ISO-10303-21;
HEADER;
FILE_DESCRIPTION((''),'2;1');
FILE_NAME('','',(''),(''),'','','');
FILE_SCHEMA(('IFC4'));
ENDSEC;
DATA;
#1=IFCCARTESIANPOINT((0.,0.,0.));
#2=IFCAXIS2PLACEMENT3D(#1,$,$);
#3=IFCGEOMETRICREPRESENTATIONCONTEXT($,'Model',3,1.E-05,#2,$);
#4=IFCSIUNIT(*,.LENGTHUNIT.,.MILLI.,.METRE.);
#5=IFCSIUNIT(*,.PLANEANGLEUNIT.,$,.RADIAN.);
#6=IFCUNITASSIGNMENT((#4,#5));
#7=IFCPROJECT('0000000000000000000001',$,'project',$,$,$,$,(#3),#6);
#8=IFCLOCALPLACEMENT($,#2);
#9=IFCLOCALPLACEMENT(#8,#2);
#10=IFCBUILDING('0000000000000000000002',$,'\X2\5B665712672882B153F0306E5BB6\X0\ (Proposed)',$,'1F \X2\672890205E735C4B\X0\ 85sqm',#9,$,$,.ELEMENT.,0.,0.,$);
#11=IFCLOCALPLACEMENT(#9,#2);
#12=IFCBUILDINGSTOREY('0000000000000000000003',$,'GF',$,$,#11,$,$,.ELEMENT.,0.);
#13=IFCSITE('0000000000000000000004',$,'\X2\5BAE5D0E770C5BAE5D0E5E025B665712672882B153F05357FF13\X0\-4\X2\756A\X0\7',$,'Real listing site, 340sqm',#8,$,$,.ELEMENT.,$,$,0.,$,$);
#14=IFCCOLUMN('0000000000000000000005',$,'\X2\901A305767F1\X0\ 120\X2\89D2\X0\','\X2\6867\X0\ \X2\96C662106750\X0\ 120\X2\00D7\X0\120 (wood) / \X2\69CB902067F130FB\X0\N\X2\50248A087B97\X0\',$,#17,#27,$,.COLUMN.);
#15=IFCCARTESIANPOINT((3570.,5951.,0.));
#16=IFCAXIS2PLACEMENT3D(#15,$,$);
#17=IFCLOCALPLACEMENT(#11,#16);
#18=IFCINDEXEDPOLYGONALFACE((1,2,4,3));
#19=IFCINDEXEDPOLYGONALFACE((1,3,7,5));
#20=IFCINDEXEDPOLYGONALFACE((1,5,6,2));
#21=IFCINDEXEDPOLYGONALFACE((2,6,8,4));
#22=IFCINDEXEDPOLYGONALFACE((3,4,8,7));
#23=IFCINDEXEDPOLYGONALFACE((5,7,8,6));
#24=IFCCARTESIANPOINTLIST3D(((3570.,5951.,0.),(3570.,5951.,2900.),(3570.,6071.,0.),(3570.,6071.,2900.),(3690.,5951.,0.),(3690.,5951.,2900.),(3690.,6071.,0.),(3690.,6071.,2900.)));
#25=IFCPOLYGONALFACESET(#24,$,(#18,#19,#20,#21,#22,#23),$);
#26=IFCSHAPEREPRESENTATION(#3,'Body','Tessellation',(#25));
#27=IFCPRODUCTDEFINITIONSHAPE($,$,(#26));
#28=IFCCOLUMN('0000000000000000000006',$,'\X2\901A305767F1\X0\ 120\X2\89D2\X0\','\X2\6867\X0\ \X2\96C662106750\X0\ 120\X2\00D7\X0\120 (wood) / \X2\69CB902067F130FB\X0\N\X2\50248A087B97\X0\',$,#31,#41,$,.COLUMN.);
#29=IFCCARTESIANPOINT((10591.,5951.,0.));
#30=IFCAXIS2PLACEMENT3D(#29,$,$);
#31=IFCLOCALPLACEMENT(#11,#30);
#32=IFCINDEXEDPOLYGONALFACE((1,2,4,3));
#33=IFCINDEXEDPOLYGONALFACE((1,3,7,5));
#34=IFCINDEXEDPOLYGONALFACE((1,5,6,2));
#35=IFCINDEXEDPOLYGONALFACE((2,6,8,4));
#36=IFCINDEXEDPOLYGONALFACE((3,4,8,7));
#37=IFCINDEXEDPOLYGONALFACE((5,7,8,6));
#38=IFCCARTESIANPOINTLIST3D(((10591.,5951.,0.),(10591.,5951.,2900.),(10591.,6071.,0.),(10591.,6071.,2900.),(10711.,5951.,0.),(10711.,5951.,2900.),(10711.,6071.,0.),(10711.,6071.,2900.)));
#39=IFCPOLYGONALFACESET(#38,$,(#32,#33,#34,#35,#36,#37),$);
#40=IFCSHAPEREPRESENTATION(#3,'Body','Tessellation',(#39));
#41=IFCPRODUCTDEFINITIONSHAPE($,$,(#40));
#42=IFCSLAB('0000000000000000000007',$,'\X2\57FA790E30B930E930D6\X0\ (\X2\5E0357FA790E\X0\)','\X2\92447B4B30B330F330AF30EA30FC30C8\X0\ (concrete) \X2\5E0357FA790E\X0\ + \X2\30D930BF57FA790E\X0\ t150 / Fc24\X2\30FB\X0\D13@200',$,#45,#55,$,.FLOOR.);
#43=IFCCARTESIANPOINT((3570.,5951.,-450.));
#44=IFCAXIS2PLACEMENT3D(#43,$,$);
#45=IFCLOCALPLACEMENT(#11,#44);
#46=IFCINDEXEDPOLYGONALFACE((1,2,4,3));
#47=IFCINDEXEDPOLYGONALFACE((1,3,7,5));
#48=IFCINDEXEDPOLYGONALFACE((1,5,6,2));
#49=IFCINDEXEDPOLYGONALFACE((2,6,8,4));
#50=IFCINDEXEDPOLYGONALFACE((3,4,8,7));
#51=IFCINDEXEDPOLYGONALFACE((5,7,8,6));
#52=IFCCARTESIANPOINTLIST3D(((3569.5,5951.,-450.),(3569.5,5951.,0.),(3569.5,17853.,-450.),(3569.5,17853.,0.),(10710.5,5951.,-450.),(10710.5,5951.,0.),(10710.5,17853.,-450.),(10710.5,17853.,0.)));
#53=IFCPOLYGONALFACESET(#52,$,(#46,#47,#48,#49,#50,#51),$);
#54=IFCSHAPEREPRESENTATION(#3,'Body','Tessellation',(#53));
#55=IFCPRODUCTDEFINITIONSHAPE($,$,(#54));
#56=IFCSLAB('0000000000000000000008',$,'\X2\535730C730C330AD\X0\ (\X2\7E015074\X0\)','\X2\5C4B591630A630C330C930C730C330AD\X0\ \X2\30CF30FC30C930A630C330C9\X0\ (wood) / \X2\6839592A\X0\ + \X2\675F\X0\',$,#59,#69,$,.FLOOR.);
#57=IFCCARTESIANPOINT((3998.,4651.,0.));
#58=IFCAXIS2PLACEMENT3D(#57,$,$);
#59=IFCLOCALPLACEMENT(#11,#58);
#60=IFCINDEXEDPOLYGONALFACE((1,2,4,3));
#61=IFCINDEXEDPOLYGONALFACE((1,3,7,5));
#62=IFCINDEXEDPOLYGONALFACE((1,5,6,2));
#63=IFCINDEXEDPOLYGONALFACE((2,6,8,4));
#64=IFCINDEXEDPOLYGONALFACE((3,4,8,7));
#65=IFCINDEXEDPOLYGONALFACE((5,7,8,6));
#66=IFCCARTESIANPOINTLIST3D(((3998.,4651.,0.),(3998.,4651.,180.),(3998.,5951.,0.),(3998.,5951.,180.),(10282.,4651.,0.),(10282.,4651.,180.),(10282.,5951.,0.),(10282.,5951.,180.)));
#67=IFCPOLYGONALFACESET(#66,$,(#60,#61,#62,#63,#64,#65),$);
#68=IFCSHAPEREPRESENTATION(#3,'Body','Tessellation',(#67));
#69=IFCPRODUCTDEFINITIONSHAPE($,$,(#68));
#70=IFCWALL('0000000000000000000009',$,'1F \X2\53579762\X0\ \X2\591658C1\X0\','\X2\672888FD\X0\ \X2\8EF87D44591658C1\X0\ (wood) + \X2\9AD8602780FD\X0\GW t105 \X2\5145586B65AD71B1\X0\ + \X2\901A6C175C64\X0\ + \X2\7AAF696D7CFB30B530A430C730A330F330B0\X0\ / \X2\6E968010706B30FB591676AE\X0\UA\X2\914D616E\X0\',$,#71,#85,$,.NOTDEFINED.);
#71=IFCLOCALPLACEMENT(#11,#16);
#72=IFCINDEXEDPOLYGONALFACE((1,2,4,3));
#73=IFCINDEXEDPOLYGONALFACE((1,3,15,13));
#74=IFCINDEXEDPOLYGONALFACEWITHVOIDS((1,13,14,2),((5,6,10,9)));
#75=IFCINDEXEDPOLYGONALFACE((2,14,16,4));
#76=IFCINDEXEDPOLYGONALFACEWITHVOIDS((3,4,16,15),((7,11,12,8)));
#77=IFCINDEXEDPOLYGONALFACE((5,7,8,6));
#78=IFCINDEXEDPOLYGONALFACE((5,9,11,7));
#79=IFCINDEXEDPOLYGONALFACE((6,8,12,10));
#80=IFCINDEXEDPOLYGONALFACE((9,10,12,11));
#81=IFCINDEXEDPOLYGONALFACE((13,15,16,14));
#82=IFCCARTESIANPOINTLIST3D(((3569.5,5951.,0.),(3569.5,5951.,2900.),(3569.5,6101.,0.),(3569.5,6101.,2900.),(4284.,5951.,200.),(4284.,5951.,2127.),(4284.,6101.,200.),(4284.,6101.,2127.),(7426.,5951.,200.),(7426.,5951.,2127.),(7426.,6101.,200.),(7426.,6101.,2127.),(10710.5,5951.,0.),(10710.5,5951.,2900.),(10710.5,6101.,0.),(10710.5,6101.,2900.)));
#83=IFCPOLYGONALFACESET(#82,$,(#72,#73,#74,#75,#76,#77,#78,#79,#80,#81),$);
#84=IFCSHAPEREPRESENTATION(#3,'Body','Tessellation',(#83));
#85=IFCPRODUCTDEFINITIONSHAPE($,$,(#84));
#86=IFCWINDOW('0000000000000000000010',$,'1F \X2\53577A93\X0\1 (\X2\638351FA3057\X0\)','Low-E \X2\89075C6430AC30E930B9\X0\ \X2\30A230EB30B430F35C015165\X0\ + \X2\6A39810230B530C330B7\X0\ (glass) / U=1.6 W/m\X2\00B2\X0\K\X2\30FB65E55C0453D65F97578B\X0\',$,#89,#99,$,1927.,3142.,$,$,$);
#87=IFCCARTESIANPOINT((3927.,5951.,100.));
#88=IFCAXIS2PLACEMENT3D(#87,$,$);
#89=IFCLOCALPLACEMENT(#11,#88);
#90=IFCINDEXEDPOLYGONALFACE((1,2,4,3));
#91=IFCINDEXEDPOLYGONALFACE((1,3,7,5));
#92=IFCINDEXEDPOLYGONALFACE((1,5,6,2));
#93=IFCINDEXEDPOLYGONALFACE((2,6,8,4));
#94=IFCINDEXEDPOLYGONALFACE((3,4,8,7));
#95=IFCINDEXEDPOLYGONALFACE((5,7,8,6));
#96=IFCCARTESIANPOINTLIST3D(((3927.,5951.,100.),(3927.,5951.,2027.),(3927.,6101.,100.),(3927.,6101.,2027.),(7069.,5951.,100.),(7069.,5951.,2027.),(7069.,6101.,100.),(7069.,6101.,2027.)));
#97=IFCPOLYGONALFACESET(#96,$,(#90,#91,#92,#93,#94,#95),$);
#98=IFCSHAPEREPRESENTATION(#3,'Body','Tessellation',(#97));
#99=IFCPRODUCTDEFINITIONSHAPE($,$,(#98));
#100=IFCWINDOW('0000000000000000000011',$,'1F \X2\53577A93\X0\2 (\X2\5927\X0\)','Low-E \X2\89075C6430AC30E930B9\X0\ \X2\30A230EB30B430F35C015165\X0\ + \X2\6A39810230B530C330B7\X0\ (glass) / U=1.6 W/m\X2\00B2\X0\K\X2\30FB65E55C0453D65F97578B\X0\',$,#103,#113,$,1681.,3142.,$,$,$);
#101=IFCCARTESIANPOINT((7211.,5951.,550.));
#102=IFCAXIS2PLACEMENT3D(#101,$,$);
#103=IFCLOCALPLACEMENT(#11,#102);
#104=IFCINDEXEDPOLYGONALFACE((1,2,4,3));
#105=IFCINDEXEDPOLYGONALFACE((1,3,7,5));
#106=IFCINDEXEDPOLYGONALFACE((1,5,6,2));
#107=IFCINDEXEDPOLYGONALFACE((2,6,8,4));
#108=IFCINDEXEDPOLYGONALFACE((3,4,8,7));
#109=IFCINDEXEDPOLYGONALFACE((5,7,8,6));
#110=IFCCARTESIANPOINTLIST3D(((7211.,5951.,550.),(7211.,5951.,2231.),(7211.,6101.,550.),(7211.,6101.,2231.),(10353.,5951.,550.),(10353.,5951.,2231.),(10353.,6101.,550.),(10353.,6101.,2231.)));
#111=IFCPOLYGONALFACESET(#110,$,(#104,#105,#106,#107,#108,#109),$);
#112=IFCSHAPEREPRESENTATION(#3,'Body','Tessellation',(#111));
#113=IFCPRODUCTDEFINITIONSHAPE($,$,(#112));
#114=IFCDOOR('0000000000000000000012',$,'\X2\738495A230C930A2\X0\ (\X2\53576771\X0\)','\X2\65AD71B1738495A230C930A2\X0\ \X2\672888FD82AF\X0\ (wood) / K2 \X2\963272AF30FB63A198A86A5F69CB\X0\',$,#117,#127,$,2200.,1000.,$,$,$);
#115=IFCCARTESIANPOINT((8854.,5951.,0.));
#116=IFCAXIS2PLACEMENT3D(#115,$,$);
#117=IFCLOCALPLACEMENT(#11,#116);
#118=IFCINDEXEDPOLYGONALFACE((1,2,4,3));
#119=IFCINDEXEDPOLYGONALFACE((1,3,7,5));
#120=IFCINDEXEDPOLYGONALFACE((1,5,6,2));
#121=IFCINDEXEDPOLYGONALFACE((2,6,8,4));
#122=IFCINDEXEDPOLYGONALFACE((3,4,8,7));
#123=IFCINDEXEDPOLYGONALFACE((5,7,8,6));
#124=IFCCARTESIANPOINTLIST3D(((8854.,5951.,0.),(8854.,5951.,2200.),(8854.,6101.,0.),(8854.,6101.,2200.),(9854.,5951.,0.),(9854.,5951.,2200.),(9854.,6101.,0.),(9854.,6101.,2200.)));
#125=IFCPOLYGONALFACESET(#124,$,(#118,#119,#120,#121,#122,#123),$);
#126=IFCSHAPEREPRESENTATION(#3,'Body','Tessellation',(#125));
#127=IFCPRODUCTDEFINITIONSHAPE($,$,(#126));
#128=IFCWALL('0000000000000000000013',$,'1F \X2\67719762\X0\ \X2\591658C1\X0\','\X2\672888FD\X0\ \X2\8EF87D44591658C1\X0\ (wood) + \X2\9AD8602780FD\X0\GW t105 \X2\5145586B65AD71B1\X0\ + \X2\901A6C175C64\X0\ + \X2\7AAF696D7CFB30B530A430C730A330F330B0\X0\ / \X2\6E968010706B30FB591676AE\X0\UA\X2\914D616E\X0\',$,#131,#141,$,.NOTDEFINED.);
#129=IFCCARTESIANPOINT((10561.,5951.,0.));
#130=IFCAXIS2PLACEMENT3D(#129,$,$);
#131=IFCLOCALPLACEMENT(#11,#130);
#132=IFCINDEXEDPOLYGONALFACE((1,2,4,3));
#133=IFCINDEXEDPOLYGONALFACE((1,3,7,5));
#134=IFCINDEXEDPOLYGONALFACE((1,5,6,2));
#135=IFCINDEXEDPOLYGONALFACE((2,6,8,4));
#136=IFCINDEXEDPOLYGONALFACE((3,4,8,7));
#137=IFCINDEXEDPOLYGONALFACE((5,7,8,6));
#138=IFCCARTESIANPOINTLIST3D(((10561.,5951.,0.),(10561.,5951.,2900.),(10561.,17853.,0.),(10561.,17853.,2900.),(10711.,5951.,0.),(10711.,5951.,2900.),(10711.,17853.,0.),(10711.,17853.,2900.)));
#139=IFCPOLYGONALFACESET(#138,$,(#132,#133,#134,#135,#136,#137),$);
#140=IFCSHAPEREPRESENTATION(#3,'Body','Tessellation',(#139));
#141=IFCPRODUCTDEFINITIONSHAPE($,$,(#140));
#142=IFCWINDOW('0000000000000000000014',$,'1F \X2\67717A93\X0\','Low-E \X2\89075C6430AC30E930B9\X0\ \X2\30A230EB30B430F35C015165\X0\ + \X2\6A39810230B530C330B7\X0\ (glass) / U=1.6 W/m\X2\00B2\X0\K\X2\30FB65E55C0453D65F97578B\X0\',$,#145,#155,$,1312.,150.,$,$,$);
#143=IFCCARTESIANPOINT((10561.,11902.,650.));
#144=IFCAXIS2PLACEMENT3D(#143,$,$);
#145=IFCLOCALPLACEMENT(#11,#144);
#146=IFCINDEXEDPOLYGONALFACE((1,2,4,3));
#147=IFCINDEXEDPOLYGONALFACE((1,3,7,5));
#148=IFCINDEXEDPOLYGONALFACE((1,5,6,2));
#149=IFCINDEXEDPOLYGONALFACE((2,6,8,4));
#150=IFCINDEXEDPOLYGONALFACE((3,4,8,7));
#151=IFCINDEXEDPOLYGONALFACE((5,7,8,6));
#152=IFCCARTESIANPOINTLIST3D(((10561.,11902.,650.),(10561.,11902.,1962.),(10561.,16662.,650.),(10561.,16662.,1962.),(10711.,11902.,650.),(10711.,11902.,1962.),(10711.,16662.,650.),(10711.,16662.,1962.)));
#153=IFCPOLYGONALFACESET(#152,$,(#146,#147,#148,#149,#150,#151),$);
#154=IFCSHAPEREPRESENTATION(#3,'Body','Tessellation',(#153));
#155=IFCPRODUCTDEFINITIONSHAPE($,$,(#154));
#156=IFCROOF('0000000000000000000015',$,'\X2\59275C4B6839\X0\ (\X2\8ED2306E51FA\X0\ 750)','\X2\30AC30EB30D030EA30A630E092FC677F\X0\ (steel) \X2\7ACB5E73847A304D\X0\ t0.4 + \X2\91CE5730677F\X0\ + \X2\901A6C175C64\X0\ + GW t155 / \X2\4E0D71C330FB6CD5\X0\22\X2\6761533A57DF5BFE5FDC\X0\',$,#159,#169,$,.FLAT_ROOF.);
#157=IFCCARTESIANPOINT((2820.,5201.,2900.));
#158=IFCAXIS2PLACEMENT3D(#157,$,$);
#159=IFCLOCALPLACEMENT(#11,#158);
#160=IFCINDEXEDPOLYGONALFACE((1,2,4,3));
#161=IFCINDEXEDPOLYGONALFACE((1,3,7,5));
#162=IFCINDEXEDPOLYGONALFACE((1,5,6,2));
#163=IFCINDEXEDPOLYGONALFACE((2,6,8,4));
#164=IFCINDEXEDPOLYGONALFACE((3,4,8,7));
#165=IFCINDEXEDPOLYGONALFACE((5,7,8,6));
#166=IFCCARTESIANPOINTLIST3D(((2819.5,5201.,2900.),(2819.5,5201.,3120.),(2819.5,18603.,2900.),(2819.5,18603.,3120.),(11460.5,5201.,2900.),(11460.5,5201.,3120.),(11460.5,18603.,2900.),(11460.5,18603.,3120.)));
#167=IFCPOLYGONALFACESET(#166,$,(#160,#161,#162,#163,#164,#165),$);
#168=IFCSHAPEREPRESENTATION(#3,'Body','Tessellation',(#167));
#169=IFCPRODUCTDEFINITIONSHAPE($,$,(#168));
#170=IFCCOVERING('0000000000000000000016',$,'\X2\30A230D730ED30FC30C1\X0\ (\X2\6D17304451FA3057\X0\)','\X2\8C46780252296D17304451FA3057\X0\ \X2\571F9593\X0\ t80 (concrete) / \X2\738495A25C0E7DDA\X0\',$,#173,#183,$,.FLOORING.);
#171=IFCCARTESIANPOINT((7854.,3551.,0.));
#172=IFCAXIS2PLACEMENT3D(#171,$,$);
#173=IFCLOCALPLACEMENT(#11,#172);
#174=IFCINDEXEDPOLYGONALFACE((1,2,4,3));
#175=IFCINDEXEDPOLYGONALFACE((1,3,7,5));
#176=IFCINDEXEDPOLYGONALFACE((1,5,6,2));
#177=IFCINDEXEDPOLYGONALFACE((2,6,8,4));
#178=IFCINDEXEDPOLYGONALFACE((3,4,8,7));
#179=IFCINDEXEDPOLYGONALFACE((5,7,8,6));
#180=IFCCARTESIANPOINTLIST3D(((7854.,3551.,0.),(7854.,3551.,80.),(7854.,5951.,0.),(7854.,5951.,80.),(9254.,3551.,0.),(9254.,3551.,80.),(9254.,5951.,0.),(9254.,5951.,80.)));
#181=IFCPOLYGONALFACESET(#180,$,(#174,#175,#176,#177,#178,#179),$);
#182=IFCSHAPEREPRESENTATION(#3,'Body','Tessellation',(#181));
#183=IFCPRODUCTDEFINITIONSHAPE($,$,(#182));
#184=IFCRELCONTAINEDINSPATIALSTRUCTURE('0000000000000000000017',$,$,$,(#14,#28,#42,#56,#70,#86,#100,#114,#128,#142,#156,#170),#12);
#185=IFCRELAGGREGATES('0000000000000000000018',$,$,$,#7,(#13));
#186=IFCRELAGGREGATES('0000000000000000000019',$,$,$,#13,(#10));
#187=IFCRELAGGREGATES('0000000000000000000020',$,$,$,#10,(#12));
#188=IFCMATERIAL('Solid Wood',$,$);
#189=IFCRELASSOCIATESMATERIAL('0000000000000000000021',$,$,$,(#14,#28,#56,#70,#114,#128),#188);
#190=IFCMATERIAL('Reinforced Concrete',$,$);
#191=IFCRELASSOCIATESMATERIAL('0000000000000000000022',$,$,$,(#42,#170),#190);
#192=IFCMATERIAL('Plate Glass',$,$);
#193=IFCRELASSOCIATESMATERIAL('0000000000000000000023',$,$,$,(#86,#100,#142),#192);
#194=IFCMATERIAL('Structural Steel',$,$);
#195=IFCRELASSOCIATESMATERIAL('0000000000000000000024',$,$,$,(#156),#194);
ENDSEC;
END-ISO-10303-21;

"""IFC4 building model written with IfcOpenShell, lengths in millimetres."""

from ifc_helpers import new_model, si_unit, frame, frame_2d, origin, place, context, project, spatial, rectangle, extrude, material, element, fill, save


model = new_model("IFC4")

# Units and contexts
model_context = context("Model", 3, precision=1e-05, world=origin())
ifc_project = project(units=[si_unit("LENGTHUNIT", "METRE", prefix="MILLI"), si_unit("PLANEANGLEUNIT", "RADIAN")], contexts=[model_context])

# Site, building, storey
site_placement = place(None, origin())
site = spatial("IfcSite", under=ifc_project, at=site_placement, Name="宮崎県宮崎市学園木花台南３-4番7", ObjectType="Real listing site, 340sqm", CompositionType="ELEMENT", RefElevation=0.0)
building_placement = place(site_placement, origin())
building = spatial("IfcBuilding", under=site, at=building_placement, Name="学園木花台の家 (Proposed)", ObjectType="1F 木造平屋 85sqm", CompositionType="ELEMENT", ElevationOfRefHeight=0.0, ElevationOfTerrain=0.0)
storey_placement = place(building_placement, origin())
storey = spatial("IfcBuildingStorey", under=building, at=storey_placement, Name="GF", CompositionType="ELEMENT", Elevation=0.0)

# Columns
ifc_material_1 = material(Name="Solid Wood")
column_1_placement = place(storey_placement, frame((3570.0, 5951.0, 0.0)))
element("IfcColumn", 1, at=column_1_placement, inside=storey, material=ifc_material_1, Name="通し柱 120角", Description="桧 集成材 120×120 (wood) / 構造柱・N値計算", PredefinedType="COLUMN", context=model_context, shape_type="SweptSolid", body=[
    extrude(rectangle(XDim=120.0, YDim=120.0, at=frame_2d((60.0, 60.0))), frame((3570.0, 5951.0, 0.0)), (0.0, 0.0, 1.0), 2900.0),
])
column_2_placement = place(storey_placement, frame((10591.0, 5951.0, 0.0)))
element("IfcColumn", 2, at=column_2_placement, inside=storey, material=ifc_material_1, Name="通し柱 120角", Description="桧 集成材 120×120 (wood) / 構造柱・N値計算", PredefinedType="COLUMN", context=model_context, shape_type="SweptSolid", body=[
    extrude(rectangle(XDim=120.0, YDim=120.0, at=frame_2d((60.0, 60.0))), frame((10591.0, 5951.0, 0.0)), (0.0, 0.0, 1.0), 2900.0),
])

# Slabs
ifc_material_2 = material(Name="Reinforced Concrete")
slab_1_placement = place(storey_placement, frame((3570.0, 5951.0, -450.0)))
element("IfcSlab", 3, at=slab_1_placement, inside=storey, material=ifc_material_2, Name="基礎スラブ (布基礎)", Description="鉄筋コンクリート (concrete) 布基礎 + ベタ基礎 t150 / Fc24・D13@200", PredefinedType="FLOOR", context=model_context, shape_type="SweptSolid", body=[
    extrude(rectangle(XDim=7141.0, YDim=11902.0, at=frame_2d((3570.0, 5951.0))), frame((3570.0, 5951.0, -450.0)), (0.0, 0.0, 1.0), 450.0),
])
slab_2_placement = place(storey_placement, frame((3998.0, 4651.0, 0.0)))
element("IfcSlab", 4, at=slab_2_placement, inside=storey, material=ifc_material_1, Name="南デッキ (縁側)", Description="屋外ウッドデッキ ハードウッド (wood) / 根太 + 束", PredefinedType="FLOOR", context=model_context, shape_type="SweptSolid", body=[
    extrude(rectangle(XDim=6284.0, YDim=1300.0, at=frame_2d((3142.0, 650.0))), frame((3998.0, 4651.0, 0.0)), (0.0, 0.0, 1.0), 180.0),
])

# Wall, openings, windows, door
wall_1_placement = place(storey_placement, frame((3570.0, 5951.0, 0.0)))
wall_1 = element("IfcWall", 5, at=wall_1_placement, inside=storey, material=ifc_material_1, Name="1F 南面 外壁", Description="木製 軸組外壁 (wood) + 高性能GW t105 充填断熱 + 通気層 + 窯業系サイディング / 準耐火・外皮UA配慮", PredefinedType="NOTDEFINED", context=model_context, shape_type="SweptSolid", body=[
    extrude(rectangle(XDim=7141.0, YDim=150.0, at=frame_2d((3570.0, 75.0))), frame((3570.0, 5951.0, 0.0)), (0.0, 0.0, 1.0), 2900.0),
])
opening_1_placement = place(storey_placement, frame((3927.0, 5951.0, 100.0)))
opening_1 = element("IfcOpeningElement", 6, at=opening_1_placement, cuts=wall_1, PredefinedType="NOTDEFINED", context=model_context, shape_type="SweptSolid", body=[
    extrude(rectangle(XDim=3142.0, YDim=150.0, at=frame_2d((1571.0, 75.0))), frame((3927.0, 5951.0, 100.0)), (0.0, 0.0, 1.0), 1927.0),
])
opening_2_placement = place(storey_placement, frame((7211.0, 5951.0, 550.0)))
opening_2 = element("IfcOpeningElement", 7, at=opening_2_placement, cuts=wall_1, PredefinedType="NOTDEFINED", context=model_context, shape_type="SweptSolid", body=[
    extrude(rectangle(XDim=3142.0, YDim=150.0, at=frame_2d((1571.0, 75.0))), frame((7211.0, 5951.0, 550.0)), (0.0, 0.0, 1.0), 1681.0),
])
opening_3_placement = place(storey_placement, frame((8854.0, 5951.0, 0.0)))
opening_3 = element("IfcOpeningElement", 8, at=opening_3_placement, cuts=wall_1, PredefinedType="NOTDEFINED", context=model_context, shape_type="SweptSolid", body=[
    extrude(rectangle(XDim=1000.0, YDim=150.0, at=frame_2d((500.0, 75.0))), frame((8854.0, 5951.0, 0.0)), (0.0, 0.0, 1.0), 2200.0),
])
ifc_material_3 = material(Name="Plate Glass")
window_1_placement = place(storey_placement, frame((3927.0, 5951.0, 100.0)))
window_1 = element("IfcWindow", 9, at=window_1_placement, inside=storey, material=ifc_material_3, Name="1F 南窓1 (掃出し)", Description="Low-E 複層ガラス アルゴン封入 + 樹脂サッシ (glass) / U=1.6 W/m²K・日射取得型", OverallHeight=1927.0, OverallWidth=3142.0, context=model_context, shape_type="SweptSolid", body=[
    extrude(rectangle(XDim=3142.0, YDim=150.0, at=frame_2d((1571.0, 75.0))), frame((3927.0, 5951.0, 100.0)), (0.0, 0.0, 1.0), 1927.0),
])
fill(opening_1, window_1)
window_2_placement = place(storey_placement, frame((7211.0, 5951.0, 550.0)))
window_2 = element("IfcWindow", 10, at=window_2_placement, inside=storey, material=ifc_material_3, Name="1F 南窓2 (大)", Description="Low-E 複層ガラス アルゴン封入 + 樹脂サッシ (glass) / U=1.6 W/m²K・日射取得型", OverallHeight=1681.0, OverallWidth=3142.0, context=model_context, shape_type="SweptSolid", body=[
    extrude(rectangle(XDim=3142.0, YDim=150.0, at=frame_2d((1571.0, 75.0))), frame((7211.0, 5951.0, 550.0)), (0.0, 0.0, 1.0), 1681.0),
])
fill(opening_2, window_2)
door_placement = place(storey_placement, frame((8854.0, 5951.0, 0.0)))
door = element("IfcDoor", 11, at=door_placement, inside=storey, material=ifc_material_1, Name="玄関ドア (南東)", Description="断熱玄関ドア 木製芯 (wood) / K2 防犯・採風機構", OverallHeight=2200.0, OverallWidth=1000.0, context=model_context, shape_type="SweptSolid", body=[
    extrude(rectangle(XDim=1000.0, YDim=150.0, at=frame_2d((500.0, 75.0))), frame((8854.0, 5951.0, 0.0)), (0.0, 0.0, 1.0), 2200.0),
])
fill(opening_3, door)

# Wall, opening, window
wall_2_placement = place(storey_placement, frame((10561.0, 5951.0, 0.0)))
wall_2 = element("IfcWall", 12, at=wall_2_placement, inside=storey, material=ifc_material_1, Name="1F 東面 外壁", Description="木製 軸組外壁 (wood) + 高性能GW t105 充填断熱 + 通気層 + 窯業系サイディング / 準耐火・外皮UA配慮", PredefinedType="NOTDEFINED", context=model_context, shape_type="SweptSolid", body=[
    extrude(rectangle(XDim=150.0, YDim=11902.0, at=frame_2d((75.0, 5951.0))), frame((10561.0, 5951.0, 0.0)), (0.0, 0.0, 1.0), 2900.0),
])
opening_4_placement = place(storey_placement, frame((10561.0, 11902.0, 650.0)))
opening_4 = element("IfcOpeningElement", 13, at=opening_4_placement, cuts=wall_2, PredefinedType="NOTDEFINED", context=model_context, shape_type="SweptSolid", body=[
    extrude(rectangle(XDim=150.0, YDim=4760.0, at=frame_2d((75.0, 2380.0))), frame((10561.0, 11902.0, 650.0)), (0.0, 0.0, 1.0), 1312.0),
])
window_3_placement = place(storey_placement, frame((10561.0, 11902.0, 650.0)))
window_3 = element("IfcWindow", 14, at=window_3_placement, inside=storey, material=ifc_material_3, Name="1F 東窓", Description="Low-E 複層ガラス アルゴン封入 + 樹脂サッシ (glass) / U=1.6 W/m²K・日射取得型", OverallHeight=1312.0, OverallWidth=150.0, context=model_context, shape_type="SweptSolid", body=[
    extrude(rectangle(XDim=150.0, YDim=4760.0, at=frame_2d((75.0, 2380.0))), frame((10561.0, 11902.0, 650.0)), (0.0, 0.0, 1.0), 1312.0),
])
fill(opening_4, window_3)

# Roof
ifc_material_4 = material(Name="Structural Steel")
roof_placement = place(storey_placement, frame((2820.0, 5201.0, 2900.0)))
element("IfcRoof", 15, at=roof_placement, inside=storey, material=ifc_material_4, Name="大屋根 (軒の出 750)", Description="ガルバリウム鋼板 (steel) 立平葺き t0.4 + 野地板 + 通気層 + GW t155 / 不燃・法22条区域対応", PredefinedType="FLAT_ROOF", context=model_context, shape_type="SweptSolid", body=[
    extrude(rectangle(XDim=8641.0, YDim=13402.0, at=frame_2d((4320.0, 6701.0))), frame((2820.0, 5201.0, 2900.0)), (0.0, 0.0, 1.0), 220.0),
])

# Covering
covering_1_placement = place(storey_placement, frame((7854.0, 3551.0, 0.0)))
element("IfcCovering", 16, at=covering_1_placement, inside=storey, material=ifc_material_2, Name="アプローチ (洗い出し)", Description="豆砂利洗い出し 土間 t80 (concrete) / 玄関導線", PredefinedType="FLOORING", context=model_context, shape_type="SweptSolid", body=[
    extrude(rectangle(XDim=1400.0, YDim=2400.0, at=frame_2d((700.0, 1200.0))), frame((7854.0, 3551.0, 0.0)), (0.0, 0.0, 1.0), 80.0),
])

save(model, "model.ifc")
